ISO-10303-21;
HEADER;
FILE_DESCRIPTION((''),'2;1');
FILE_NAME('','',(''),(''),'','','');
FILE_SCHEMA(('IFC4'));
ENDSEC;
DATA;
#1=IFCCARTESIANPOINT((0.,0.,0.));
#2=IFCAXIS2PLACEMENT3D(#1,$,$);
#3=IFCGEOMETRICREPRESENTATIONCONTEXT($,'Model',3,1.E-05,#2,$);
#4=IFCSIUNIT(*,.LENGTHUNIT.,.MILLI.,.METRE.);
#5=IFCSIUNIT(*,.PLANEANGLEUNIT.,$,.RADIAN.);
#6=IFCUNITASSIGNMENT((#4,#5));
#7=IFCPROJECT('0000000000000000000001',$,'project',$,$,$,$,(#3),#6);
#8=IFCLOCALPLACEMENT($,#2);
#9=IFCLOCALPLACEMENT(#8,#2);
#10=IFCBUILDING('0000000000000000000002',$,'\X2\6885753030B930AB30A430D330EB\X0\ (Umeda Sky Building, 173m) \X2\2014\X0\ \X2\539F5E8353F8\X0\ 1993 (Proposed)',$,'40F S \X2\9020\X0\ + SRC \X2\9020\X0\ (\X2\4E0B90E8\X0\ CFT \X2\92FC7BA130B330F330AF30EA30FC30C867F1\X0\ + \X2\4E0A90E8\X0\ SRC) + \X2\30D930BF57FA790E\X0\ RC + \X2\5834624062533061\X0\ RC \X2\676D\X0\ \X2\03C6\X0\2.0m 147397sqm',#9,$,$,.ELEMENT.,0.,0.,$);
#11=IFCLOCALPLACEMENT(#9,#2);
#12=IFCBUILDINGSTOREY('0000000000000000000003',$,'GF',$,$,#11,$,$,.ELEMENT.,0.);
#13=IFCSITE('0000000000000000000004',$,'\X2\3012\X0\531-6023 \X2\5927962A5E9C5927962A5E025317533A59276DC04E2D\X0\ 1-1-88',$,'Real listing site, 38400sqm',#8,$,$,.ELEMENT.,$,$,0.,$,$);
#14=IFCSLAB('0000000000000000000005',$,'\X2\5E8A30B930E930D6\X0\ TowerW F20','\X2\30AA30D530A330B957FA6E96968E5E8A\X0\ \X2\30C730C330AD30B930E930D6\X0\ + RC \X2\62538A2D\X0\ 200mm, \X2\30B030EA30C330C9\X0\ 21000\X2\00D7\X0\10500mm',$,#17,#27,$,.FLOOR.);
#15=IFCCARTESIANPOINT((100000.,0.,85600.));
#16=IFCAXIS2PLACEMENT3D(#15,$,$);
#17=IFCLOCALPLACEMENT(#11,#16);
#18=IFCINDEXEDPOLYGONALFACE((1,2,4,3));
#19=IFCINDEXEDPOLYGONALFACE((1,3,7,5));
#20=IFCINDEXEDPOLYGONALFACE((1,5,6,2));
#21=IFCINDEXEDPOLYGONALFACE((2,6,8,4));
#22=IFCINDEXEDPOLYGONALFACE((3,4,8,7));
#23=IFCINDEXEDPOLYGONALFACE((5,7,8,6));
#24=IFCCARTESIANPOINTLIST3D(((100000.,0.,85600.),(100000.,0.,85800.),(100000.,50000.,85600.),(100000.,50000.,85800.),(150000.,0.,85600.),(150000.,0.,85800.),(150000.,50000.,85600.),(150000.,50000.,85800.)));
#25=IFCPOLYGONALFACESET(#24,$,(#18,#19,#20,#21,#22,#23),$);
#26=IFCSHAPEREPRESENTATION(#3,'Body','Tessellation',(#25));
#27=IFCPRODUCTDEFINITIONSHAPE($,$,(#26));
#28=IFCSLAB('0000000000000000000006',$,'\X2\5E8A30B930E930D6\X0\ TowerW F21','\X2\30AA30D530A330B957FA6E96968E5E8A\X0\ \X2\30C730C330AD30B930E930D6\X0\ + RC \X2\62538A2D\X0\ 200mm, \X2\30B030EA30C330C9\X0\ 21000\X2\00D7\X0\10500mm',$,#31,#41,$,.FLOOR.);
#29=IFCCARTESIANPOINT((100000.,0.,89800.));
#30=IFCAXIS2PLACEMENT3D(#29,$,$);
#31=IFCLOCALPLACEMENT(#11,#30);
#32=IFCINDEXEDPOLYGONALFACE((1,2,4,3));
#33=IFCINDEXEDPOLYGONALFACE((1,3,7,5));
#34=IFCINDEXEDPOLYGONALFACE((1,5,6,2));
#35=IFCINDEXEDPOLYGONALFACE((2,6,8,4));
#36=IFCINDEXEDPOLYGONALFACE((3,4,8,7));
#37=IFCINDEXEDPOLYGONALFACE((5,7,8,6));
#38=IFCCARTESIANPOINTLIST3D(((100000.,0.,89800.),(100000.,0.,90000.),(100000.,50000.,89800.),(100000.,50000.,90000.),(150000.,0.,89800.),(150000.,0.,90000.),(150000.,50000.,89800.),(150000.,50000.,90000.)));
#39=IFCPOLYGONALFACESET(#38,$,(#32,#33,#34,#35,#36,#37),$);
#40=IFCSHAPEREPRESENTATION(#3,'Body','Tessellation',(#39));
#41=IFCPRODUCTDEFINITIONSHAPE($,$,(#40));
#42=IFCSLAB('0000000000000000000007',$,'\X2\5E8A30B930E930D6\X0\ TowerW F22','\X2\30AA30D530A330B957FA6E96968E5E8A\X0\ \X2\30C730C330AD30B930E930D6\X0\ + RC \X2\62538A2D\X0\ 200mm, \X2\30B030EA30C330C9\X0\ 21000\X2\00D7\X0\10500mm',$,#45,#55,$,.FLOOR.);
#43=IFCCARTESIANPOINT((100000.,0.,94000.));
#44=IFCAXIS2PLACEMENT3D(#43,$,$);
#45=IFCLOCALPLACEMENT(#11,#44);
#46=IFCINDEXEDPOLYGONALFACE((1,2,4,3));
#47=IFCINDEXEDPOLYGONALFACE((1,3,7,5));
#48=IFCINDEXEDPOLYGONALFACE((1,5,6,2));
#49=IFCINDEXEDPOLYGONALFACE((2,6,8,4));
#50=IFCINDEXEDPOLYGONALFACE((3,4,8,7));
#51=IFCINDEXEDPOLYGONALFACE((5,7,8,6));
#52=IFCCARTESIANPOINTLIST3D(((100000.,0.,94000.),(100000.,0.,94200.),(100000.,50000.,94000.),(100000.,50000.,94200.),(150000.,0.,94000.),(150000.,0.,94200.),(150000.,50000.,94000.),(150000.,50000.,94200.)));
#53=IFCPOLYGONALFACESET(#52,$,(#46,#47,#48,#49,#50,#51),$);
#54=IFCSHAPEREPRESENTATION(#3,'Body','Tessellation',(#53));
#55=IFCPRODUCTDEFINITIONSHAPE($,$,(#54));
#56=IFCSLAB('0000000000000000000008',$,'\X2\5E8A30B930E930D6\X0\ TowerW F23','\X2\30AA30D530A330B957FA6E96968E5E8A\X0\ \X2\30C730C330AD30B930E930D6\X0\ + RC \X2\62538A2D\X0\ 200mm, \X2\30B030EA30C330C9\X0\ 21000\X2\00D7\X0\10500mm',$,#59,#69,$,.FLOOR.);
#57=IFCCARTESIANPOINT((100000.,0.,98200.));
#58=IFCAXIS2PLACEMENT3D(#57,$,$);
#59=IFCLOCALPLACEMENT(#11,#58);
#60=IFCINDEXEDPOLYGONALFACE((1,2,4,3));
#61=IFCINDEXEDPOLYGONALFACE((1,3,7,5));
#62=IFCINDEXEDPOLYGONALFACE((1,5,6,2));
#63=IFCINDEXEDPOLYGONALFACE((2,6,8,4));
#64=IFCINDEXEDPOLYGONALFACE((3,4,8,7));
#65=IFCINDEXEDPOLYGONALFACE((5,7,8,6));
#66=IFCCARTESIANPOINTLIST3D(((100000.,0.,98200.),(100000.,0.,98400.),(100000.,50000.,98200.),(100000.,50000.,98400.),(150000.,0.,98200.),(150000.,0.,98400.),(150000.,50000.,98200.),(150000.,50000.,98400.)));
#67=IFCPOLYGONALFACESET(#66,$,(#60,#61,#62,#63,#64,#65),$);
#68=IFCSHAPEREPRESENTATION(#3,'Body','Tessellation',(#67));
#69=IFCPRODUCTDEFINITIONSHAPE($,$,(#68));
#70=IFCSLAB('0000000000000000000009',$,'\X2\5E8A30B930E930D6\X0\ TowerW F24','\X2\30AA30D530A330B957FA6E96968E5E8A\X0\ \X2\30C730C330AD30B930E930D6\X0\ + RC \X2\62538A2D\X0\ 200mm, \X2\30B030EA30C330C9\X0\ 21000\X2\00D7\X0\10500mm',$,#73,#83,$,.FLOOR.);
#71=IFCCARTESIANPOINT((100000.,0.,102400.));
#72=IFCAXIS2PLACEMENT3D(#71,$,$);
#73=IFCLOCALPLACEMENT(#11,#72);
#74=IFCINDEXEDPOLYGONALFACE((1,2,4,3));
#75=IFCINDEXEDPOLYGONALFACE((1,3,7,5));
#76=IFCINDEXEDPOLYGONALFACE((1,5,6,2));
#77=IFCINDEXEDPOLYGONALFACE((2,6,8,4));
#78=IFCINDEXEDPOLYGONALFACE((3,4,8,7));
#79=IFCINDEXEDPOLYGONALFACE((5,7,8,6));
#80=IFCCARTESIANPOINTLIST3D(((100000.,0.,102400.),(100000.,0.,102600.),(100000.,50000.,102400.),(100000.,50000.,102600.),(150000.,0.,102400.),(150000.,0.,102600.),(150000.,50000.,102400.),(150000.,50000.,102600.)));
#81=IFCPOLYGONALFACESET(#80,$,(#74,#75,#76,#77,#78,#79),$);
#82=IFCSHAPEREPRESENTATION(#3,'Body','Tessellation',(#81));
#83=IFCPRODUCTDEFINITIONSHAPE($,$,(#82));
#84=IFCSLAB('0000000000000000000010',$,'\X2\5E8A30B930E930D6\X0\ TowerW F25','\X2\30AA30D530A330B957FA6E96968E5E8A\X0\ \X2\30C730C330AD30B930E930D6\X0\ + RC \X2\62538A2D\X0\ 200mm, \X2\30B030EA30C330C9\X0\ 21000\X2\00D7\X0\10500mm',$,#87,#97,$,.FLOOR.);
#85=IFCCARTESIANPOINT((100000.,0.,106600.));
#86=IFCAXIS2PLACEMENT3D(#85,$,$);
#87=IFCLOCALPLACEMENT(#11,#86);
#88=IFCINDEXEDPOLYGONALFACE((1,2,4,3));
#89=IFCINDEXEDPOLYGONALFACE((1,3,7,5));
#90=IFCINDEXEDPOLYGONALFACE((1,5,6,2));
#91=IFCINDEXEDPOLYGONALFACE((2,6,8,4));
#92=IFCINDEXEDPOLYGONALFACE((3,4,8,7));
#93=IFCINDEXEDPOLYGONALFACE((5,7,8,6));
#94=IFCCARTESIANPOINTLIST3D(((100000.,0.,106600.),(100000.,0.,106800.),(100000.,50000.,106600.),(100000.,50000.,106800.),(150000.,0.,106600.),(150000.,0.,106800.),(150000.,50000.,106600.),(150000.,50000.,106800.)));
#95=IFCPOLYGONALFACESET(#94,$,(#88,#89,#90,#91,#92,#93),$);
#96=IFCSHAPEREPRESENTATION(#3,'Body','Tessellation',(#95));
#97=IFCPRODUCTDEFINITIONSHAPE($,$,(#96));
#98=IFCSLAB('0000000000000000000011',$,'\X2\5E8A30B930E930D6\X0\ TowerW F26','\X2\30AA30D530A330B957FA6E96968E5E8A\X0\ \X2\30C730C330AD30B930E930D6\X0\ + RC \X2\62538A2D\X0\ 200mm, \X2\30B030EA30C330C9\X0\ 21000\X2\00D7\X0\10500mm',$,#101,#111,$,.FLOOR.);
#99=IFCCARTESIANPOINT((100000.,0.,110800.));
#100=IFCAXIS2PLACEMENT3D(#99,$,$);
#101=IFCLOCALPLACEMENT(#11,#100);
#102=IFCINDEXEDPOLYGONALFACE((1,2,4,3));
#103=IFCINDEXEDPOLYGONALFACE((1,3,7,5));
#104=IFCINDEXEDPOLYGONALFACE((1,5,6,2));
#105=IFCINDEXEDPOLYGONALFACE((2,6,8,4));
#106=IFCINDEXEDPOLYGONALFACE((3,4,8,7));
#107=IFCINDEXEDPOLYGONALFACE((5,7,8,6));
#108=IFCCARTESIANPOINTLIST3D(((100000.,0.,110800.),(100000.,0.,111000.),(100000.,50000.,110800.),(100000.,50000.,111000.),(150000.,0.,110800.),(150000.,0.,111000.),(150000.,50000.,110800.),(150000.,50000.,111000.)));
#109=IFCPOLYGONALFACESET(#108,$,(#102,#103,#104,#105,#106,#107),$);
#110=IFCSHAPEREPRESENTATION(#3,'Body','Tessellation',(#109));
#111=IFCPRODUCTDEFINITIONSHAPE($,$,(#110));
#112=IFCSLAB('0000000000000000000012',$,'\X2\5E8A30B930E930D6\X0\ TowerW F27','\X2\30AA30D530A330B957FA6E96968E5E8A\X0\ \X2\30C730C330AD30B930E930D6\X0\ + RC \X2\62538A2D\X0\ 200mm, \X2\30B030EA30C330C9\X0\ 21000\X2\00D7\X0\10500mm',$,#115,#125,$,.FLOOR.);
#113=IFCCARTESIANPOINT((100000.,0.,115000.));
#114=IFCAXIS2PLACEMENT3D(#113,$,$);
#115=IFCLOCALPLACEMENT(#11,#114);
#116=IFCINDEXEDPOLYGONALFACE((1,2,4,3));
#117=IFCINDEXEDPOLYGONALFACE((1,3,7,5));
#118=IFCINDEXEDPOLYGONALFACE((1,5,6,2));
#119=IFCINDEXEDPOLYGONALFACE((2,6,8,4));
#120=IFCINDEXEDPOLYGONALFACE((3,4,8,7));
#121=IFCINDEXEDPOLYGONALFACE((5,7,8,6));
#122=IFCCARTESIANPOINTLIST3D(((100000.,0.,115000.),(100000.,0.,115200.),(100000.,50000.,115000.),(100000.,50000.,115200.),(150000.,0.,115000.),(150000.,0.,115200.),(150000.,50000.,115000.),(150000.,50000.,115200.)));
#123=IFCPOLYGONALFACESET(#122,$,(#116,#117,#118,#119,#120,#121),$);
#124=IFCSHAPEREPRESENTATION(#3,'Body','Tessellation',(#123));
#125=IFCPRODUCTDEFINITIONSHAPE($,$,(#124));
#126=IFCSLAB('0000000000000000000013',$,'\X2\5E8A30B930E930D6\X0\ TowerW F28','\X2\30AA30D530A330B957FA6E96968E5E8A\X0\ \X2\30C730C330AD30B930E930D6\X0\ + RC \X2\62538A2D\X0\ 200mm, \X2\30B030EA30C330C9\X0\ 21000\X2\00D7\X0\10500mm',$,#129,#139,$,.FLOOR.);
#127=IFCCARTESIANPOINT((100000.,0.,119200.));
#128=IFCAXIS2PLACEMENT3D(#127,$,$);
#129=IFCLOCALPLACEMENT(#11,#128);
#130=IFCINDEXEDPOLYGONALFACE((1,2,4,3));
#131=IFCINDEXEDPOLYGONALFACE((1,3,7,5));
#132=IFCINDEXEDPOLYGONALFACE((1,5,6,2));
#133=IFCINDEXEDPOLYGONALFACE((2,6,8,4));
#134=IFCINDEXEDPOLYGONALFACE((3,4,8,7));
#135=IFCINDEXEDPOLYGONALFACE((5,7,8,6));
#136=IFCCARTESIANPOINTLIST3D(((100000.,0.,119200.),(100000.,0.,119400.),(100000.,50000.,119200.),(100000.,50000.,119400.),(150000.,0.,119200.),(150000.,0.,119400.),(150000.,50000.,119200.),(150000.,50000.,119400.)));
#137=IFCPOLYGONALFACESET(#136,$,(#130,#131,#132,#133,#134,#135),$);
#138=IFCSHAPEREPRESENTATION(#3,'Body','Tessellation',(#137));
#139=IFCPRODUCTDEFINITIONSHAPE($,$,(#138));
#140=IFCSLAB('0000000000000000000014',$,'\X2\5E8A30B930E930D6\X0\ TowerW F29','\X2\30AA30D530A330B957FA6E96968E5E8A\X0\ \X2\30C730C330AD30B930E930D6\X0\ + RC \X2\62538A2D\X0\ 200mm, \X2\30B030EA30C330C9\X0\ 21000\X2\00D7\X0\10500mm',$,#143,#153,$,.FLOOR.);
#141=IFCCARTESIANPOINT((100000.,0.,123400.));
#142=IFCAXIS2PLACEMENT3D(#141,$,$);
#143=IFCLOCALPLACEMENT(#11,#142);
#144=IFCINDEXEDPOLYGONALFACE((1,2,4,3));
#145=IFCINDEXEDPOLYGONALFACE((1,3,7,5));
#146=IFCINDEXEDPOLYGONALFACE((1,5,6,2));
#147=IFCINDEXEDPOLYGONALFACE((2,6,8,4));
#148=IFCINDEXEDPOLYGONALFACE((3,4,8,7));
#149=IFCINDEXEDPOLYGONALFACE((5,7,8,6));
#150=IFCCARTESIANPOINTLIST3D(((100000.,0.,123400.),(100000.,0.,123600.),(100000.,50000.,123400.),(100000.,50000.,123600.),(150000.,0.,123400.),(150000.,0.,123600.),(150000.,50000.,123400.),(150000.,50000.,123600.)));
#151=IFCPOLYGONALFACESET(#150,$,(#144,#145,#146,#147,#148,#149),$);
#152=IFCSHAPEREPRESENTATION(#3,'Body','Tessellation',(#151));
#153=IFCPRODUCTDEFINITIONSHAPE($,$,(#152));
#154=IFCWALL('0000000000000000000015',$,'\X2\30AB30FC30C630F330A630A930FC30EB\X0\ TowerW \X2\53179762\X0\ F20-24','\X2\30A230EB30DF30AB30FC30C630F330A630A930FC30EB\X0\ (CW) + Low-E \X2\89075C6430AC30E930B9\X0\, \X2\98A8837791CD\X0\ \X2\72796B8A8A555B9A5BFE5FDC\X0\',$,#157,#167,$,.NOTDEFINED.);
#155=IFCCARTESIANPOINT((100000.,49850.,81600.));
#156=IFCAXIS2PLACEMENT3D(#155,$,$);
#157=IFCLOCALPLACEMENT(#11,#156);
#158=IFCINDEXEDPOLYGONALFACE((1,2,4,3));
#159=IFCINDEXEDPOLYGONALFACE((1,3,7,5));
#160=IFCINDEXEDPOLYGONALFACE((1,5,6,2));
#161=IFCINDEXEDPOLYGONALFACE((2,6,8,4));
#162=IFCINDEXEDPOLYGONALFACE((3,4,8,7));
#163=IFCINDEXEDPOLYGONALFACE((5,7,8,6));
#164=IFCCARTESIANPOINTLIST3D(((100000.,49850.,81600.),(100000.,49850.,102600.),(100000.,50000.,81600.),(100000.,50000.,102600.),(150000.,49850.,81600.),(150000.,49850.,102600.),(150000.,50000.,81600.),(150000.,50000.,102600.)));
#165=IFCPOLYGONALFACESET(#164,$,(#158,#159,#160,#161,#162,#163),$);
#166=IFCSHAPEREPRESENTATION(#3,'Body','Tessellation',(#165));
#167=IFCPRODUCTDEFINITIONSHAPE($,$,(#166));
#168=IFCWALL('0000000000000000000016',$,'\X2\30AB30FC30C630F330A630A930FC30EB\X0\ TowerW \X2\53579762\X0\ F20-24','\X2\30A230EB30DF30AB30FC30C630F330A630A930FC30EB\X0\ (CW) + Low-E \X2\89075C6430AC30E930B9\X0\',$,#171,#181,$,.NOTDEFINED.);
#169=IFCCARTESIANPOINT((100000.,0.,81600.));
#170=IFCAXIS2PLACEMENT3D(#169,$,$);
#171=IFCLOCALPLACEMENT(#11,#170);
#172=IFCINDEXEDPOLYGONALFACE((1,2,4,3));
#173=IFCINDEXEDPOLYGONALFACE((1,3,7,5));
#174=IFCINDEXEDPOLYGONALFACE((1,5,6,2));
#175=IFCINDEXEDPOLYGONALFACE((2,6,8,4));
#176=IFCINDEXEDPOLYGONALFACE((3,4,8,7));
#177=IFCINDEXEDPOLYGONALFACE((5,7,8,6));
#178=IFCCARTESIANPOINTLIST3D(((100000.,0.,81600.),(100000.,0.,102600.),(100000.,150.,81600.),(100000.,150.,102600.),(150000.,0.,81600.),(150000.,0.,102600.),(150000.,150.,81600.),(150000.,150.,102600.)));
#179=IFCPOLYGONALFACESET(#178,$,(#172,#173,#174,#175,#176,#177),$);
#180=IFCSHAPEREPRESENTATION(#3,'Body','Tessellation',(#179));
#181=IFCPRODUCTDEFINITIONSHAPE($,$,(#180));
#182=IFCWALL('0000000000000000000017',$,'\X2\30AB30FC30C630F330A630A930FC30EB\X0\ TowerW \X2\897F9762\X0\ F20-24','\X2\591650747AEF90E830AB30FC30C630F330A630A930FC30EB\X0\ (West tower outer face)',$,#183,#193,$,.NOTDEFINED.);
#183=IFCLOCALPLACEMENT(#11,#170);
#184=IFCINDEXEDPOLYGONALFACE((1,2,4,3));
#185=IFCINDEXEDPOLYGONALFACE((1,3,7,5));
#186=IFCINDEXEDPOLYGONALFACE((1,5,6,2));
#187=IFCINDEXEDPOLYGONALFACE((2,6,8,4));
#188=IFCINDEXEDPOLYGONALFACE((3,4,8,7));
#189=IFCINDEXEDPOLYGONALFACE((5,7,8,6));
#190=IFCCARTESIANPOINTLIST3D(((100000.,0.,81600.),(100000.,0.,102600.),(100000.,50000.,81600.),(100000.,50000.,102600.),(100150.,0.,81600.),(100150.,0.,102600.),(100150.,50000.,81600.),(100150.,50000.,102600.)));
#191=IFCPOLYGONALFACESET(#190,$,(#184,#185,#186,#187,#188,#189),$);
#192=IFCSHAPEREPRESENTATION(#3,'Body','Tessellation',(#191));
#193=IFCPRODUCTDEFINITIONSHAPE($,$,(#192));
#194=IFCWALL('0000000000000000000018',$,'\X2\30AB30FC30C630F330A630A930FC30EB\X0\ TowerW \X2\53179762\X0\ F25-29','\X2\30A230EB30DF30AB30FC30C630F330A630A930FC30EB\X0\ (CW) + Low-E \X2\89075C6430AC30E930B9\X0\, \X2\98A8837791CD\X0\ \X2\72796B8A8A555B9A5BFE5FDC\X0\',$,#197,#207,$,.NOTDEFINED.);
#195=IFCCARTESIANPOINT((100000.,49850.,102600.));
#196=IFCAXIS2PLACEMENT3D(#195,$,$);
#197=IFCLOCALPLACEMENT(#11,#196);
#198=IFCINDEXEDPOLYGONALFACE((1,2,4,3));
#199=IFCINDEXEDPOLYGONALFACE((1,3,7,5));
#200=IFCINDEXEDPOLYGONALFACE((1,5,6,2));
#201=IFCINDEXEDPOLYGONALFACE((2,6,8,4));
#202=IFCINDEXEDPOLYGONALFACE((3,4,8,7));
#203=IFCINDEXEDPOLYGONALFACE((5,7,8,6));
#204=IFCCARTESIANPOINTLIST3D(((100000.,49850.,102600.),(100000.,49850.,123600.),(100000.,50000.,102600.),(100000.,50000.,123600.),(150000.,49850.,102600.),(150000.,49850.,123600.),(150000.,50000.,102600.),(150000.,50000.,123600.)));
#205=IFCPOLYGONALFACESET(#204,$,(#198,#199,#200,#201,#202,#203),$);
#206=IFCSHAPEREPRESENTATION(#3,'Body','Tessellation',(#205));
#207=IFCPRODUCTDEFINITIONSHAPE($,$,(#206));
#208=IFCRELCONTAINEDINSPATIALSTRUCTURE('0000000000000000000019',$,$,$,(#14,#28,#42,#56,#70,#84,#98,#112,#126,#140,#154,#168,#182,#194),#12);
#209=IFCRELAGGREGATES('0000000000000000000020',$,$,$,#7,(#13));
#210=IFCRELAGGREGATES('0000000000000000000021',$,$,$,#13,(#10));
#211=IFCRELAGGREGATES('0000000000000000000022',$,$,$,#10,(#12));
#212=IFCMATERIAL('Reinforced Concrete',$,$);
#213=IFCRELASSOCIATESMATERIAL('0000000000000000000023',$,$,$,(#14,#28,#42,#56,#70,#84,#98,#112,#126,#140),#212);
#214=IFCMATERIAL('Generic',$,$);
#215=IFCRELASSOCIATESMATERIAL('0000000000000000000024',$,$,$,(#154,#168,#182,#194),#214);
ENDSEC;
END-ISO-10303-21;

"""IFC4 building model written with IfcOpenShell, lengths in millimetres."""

from ifc_helpers import new_model, si_unit, frame, frame_2d, origin, place, context, project, spatial, rectangle, extrude, material, element, save


model = new_model("IFC4")

# Units and contexts
model_context = context("Model", 3, precision=1e-05, world=origin())
ifc_project = project(units=[si_unit("LENGTHUNIT", "METRE", prefix="MILLI"), si_unit("PLANEANGLEUNIT", "RADIAN")], contexts=[model_context])

# Site, building, storey
site_placement = place(None, origin())
site = spatial("IfcSite", under=ifc_project, at=site_placement, Name="〒531-6023 大阪府大阪市北区大淀中 1-1-88", ObjectType="Real listing site, 38400sqm", CompositionType="ELEMENT", RefElevation=0.0)
building_placement = place(site_placement, origin())
building = spatial("IfcBuilding", under=site, at=building_placement, Name="梅田スカイビル (Umeda Sky Building, 173m) — 原広司 1993 (Proposed)", ObjectType="40F S 造 + SRC 造 (下部 CFT 鋼管コンクリート柱 + 上部 SRC) + ベタ基礎 RC + 場所打ち RC 杭 φ2.0m 147397sqm", CompositionType="ELEMENT", ElevationOfRefHeight=0.0, ElevationOfTerrain=0.0)
storey_placement = place(building_placement, origin())
storey = spatial("IfcBuildingStorey", under=building, at=storey_placement, Name="GF", CompositionType="ELEMENT", Elevation=0.0)

# Shared definitions
ifc_material_1 = material(Name="Generic")

# Slabs
ifc_material_2 = material(Name="Reinforced Concrete")
slab_1_placement = place(storey_placement, frame((100000.0, 0.0, 85600.0)))
element("IfcSlab", 1, at=slab_1_placement, inside=storey, material=ifc_material_2, Name="床スラブ TowerW F20", Description="オフィス基準階床 デッキスラブ + RC 打設 200mm, グリッド 21000×10500mm", PredefinedType="FLOOR", context=model_context, shape_type="SweptSolid", body=[
    extrude(rectangle(XDim=50000.0, YDim=50000.0, at=frame_2d((25000.0, 25000.0))), frame((100000.0, 0.0, 85600.0)), (0.0, 0.0, 1.0), 200.0),
])
slab_2_placement = place(storey_placement, frame((100000.0, 0.0, 89800.0)))
element("IfcSlab", 2, at=slab_2_placement, inside=storey, material=ifc_material_2, Name="床スラブ TowerW F21", Description="オフィス基準階床 デッキスラブ + RC 打設 200mm, グリッド 21000×10500mm", PredefinedType="FLOOR", context=model_context, shape_type="SweptSolid", body=[
    extrude(rectangle(XDim=50000.0, YDim=50000.0, at=frame_2d((25000.0, 25000.0))), frame((100000.0, 0.0, 89800.0)), (0.0, 0.0, 1.0), 200.0),
])
slab_3_placement = place(storey_placement, frame((100000.0, 0.0, 94000.0)))
element("IfcSlab", 3, at=slab_3_placement, inside=storey, material=ifc_material_2, Name="床スラブ TowerW F22", Description="オフィス基準階床 デッキスラブ + RC 打設 200mm, グリッド 21000×10500mm", PredefinedType="FLOOR", context=model_context, shape_type="SweptSolid", body=[
    extrude(rectangle(XDim=50000.0, YDim=50000.0, at=frame_2d((25000.0, 25000.0))), frame((100000.0, 0.0, 94000.0)), (0.0, 0.0, 1.0), 200.0),
])
slab_4_placement = place(storey_placement, frame((100000.0, 0.0, 98200.0)))
element("IfcSlab", 4, at=slab_4_placement, inside=storey, material=ifc_material_2, Name="床スラブ TowerW F23", Description="オフィス基準階床 デッキスラブ + RC 打設 200mm, グリッド 21000×10500mm", PredefinedType="FLOOR", context=model_context, shape_type="SweptSolid", body=[
    extrude(rectangle(XDim=50000.0, YDim=50000.0, at=frame_2d((25000.0, 25000.0))), frame((100000.0, 0.0, 98200.0)), (0.0, 0.0, 1.0), 200.0),
])
slab_5_placement = place(storey_placement, frame((100000.0, 0.0, 102400.0)))
element("IfcSlab", 5, at=slab_5_placement, inside=storey, material=ifc_material_2, Name="床スラブ TowerW F24", Description="オフィス基準階床 デッキスラブ + RC 打設 200mm, グリッド 21000×10500mm", PredefinedType="FLOOR", context=model_context, shape_type="SweptSolid", body=[
    extrude(rectangle(XDim=50000.0, YDim=50000.0, at=frame_2d((25000.0, 25000.0))), frame((100000.0, 0.0, 102400.0)), (0.0, 0.0, 1.0), 200.0),
])
slab_6_placement = place(storey_placement, frame((100000.0, 0.0, 106600.0)))
element("IfcSlab", 6, at=slab_6_placement, inside=storey, material=ifc_material_2, Name="床スラブ TowerW F25", Description="オフィス基準階床 デッキスラブ + RC 打設 200mm, グリッド 21000×10500mm", PredefinedType="FLOOR", context=model_context, shape_type="SweptSolid", body=[
    extrude(rectangle(XDim=50000.0, YDim=50000.0, at=frame_2d((25000.0, 25000.0))), frame((100000.0, 0.0, 106600.0)), (0.0, 0.0, 1.0), 200.0),
])
slab_7_placement = place(storey_placement, frame((100000.0, 0.0, 110800.0)))
element("IfcSlab", 7, at=slab_7_placement, inside=storey, material=ifc_material_2, Name="床スラブ TowerW F26", Description="オフィス基準階床 デッキスラブ + RC 打設 200mm, グリッド 21000×10500mm", PredefinedType="FLOOR", context=model_context, shape_type="SweptSolid", body=[
    extrude(rectangle(XDim=50000.0, YDim=50000.0, at=frame_2d((25000.0, 25000.0))), frame((100000.0, 0.0, 110800.0)), (0.0, 0.0, 1.0), 200.0),
])
slab_8_placement = place(storey_placement, frame((100000.0, 0.0, 115000.0)))
element("IfcSlab", 8, at=slab_8_placement, inside=storey, material=ifc_material_2, Name="床スラブ TowerW F27", Description="オフィス基準階床 デッキスラブ + RC 打設 200mm, グリッド 21000×10500mm", PredefinedType="FLOOR", context=model_context, shape_type="SweptSolid", body=[
    extrude(rectangle(XDim=50000.0, YDim=50000.0, at=frame_2d((25000.0, 25000.0))), frame((100000.0, 0.0, 115000.0)), (0.0, 0.0, 1.0), 200.0),
])
slab_9_placement = place(storey_placement, frame((100000.0, 0.0, 119200.0)))
element("IfcSlab", 9, at=slab_9_placement, inside=storey, material=ifc_material_2, Name="床スラブ TowerW F28", Description="オフィス基準階床 デッキスラブ + RC 打設 200mm, グリッド 21000×10500mm", PredefinedType="FLOOR", context=model_context, shape_type="SweptSolid", body=[
    extrude(rectangle(XDim=50000.0, YDim=50000.0, at=frame_2d((25000.0, 25000.0))), frame((100000.0, 0.0, 119200.0)), (0.0, 0.0, 1.0), 200.0),
])
slab_10_placement = place(storey_placement, frame((100000.0, 0.0, 123400.0)))
element("IfcSlab", 10, at=slab_10_placement, inside=storey, material=ifc_material_2, Name="床スラブ TowerW F29", Description="オフィス基準階床 デッキスラブ + RC 打設 200mm, グリッド 21000×10500mm", PredefinedType="FLOOR", context=model_context, shape_type="SweptSolid", body=[
    extrude(rectangle(XDim=50000.0, YDim=50000.0, at=frame_2d((25000.0, 25000.0))), frame((100000.0, 0.0, 123400.0)), (0.0, 0.0, 1.0), 200.0),
])

# Walls
wall_1_placement = place(storey_placement, frame((100000.0, 49850.0, 81600.0)))
element("IfcWall", 11, at=wall_1_placement, inside=storey, material=ifc_material_1, Name="カーテンウォール TowerW 北面 F20-24", Description="アルミカーテンウォール (CW) + Low-E 複層ガラス, 風荷重 特殊評定対応", PredefinedType="NOTDEFINED", context=model_context, shape_type="SweptSolid", body=[
    extrude(rectangle(XDim=50000.0, YDim=150.0, at=frame_2d((25000.0, 75.0))), frame((100000.0, 49850.0, 81600.0)), (0.0, 0.0, 1.0), 21000.0),
])
wall_2_placement = place(storey_placement, frame((100000.0, 0.0, 81600.0)))
element("IfcWall", 12, at=wall_2_placement, inside=storey, material=ifc_material_1, Name="カーテンウォール TowerW 南面 F20-24", Description="アルミカーテンウォール (CW) + Low-E 複層ガラス", PredefinedType="NOTDEFINED", context=model_context, shape_type="SweptSolid", body=[
    extrude(rectangle(XDim=50000.0, YDim=150.0, at=frame_2d((25000.0, 75.0))), frame((100000.0, 0.0, 81600.0)), (0.0, 0.0, 1.0), 21000.0),
])
wall_3_placement = place(storey_placement, frame((100000.0, 0.0, 81600.0)))
element("IfcWall", 13, at=wall_3_placement, inside=storey, material=ifc_material_1, Name="カーテンウォール TowerW 西面 F20-24", Description="外側端部カーテンウォール (West tower outer face)", PredefinedType="NOTDEFINED", context=model_context, shape_type="SweptSolid", body=[
    extrude(rectangle(XDim=150.0, YDim=50000.0, at=frame_2d((75.0, 25000.0))), frame((100000.0, 0.0, 81600.0)), (0.0, 0.0, 1.0), 21000.0),
])
wall_4_placement = place(storey_placement, frame((100000.0, 49850.0, 102600.0)))
element("IfcWall", 14, at=wall_4_placement, inside=storey, material=ifc_material_1, Name="カーテンウォール TowerW 北面 F25-29", Description="アルミカーテンウォール (CW) + Low-E 複層ガラス, 風荷重 特殊評定対応", PredefinedType="NOTDEFINED", context=model_context, shape_type="SweptSolid", body=[
    extrude(rectangle(XDim=50000.0, YDim=150.0, at=frame_2d((25000.0, 75.0))), frame((100000.0, 49850.0, 102600.0)), (0.0, 0.0, 1.0), 21000.0),
])

save(model, "model.ifc")
